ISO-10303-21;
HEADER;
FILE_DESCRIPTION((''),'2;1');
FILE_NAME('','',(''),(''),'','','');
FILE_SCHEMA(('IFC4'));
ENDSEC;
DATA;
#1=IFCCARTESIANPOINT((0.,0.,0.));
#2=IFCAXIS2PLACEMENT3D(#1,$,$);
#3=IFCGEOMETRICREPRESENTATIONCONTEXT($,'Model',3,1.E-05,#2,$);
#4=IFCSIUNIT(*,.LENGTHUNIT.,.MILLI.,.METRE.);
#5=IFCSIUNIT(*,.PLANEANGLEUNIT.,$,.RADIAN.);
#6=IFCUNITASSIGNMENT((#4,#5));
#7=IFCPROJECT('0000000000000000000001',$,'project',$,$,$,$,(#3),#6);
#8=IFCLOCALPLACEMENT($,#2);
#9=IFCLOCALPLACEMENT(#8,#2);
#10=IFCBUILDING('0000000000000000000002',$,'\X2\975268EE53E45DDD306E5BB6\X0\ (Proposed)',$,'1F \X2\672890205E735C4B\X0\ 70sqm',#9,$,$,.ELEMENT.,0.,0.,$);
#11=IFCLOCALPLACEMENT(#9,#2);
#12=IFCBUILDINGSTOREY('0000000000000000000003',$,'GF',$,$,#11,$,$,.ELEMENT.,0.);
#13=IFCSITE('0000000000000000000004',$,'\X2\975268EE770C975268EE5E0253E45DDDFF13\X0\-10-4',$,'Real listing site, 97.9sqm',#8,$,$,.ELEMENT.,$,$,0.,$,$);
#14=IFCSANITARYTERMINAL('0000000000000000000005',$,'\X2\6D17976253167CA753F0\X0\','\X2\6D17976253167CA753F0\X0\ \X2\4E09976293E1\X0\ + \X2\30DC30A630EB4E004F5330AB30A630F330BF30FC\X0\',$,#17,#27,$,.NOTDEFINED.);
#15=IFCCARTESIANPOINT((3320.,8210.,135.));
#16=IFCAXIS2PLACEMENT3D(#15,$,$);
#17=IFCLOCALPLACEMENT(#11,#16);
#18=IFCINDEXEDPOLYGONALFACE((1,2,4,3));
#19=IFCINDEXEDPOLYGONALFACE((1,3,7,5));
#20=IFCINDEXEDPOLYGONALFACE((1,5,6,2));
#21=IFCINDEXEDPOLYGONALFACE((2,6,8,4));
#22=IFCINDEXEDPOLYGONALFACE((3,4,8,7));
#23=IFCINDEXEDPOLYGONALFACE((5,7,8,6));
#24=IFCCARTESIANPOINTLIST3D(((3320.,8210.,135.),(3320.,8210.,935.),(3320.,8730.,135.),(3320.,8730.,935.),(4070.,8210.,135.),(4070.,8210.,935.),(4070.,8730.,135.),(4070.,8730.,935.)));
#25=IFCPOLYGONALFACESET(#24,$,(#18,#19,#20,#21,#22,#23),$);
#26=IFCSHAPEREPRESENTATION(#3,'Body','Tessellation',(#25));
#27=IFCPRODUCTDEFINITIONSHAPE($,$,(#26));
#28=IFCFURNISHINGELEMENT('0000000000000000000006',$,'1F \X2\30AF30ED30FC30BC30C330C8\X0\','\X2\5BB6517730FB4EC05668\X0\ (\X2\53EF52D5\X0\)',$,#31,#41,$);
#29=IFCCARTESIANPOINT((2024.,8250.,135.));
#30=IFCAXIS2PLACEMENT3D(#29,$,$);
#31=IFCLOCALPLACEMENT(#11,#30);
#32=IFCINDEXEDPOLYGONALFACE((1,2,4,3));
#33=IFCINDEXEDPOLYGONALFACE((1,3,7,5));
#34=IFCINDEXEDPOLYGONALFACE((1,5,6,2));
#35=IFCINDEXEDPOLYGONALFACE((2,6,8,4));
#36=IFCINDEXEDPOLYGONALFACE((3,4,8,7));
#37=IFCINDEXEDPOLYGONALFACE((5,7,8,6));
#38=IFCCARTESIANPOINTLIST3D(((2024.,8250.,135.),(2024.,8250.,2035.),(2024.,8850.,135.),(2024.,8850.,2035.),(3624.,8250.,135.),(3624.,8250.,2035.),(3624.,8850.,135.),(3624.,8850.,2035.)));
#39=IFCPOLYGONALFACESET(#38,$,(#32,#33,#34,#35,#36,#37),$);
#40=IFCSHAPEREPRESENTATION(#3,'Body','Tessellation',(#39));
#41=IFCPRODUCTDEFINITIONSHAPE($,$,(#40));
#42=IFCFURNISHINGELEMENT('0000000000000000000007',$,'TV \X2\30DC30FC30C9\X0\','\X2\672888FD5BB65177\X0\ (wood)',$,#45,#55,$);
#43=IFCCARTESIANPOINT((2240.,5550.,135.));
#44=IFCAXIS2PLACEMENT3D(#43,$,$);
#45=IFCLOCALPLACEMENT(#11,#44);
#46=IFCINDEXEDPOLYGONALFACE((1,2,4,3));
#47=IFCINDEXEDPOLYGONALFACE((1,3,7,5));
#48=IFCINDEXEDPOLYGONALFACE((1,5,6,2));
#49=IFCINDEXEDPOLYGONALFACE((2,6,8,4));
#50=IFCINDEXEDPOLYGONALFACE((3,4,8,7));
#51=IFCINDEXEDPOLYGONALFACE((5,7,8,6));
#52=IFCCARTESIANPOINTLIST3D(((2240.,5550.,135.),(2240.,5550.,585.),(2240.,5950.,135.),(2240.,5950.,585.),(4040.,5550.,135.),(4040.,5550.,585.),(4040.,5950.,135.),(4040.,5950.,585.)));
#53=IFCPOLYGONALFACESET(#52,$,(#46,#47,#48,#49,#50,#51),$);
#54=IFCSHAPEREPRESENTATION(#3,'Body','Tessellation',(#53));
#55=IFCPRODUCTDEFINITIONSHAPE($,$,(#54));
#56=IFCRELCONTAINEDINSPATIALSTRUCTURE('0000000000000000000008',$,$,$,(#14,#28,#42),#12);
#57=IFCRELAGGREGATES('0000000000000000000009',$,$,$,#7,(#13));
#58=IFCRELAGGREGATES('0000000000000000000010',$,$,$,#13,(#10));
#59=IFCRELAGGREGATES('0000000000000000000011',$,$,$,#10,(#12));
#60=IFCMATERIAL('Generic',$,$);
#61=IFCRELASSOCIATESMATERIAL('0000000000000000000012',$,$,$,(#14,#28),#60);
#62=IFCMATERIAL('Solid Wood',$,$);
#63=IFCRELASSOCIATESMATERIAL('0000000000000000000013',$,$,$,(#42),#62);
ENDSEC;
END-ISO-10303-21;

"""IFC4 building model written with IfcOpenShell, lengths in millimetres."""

from ifc_helpers import new_model, si_unit, frame, frame_2d, origin, place, context, project, spatial, rectangle, extrude, material, element, save


model = new_model("IFC4")

# Units and contexts
model_context = context("Model", 3, precision=1e-05, world=origin())
ifc_project = project(units=[si_unit("LENGTHUNIT", "METRE", prefix="MILLI"), si_unit("PLANEANGLEUNIT", "RADIAN")], contexts=[model_context])

# Site, building, storey
site_placement = place(None, origin())
site = spatial("IfcSite", under=ifc_project, at=site_placement, Name="青森県青森市古川３-10-4", ObjectType="Real listing site, 97.9sqm", CompositionType="ELEMENT", RefElevation=0.0)
building_placement = place(site_placement, origin())
building = spatial("IfcBuilding", under=site, at=building_placement, Name="青森古川の家 (Proposed)", ObjectType="1F 木造平屋 70sqm", CompositionType="ELEMENT", ElevationOfRefHeight=0.0, ElevationOfTerrain=0.0)
storey_placement = place(building_placement, origin())
storey = spatial("IfcBuildingStorey", under=building, at=storey_placement, Name="GF", CompositionType="ELEMENT", Elevation=0.0)

# Shared definitions
ifc_material_1 = material(Name="Solid Wood")

# Shared definitions
ifc_material_2 = material(Name="Generic")

# Sanitary terminal
sanitary_terminal_1_placement = place(storey_placement, frame((3320.0, 8210.0, 135.0)))
element("IfcSanitaryTerminal", 1, at=sanitary_terminal_1_placement, inside=storey, material=ifc_material_2, Name="洗面化粧台", Description="洗面化粧台 三面鏡 + ボウル一体カウンター", PredefinedType="NOTDEFINED", context=model_context, shape_type="SweptSolid", body=[
    extrude(rectangle(XDim=750.0, YDim=520.0, at=frame_2d((375.0, 260.0))), frame((3320.0, 8210.0, 135.0)), (0.0, 0.0, 1.0), 800.0),
])

# Furnishing elements
furnishing_1_placement = place(storey_placement, frame((2024.0, 8250.0, 135.0)))
element("IfcFurnishingElement", 2, at=furnishing_1_placement, inside=storey, material=ifc_material_2, Name="1F クローゼット", Description="家具・什器 (可動)", context=model_context, shape_type="SweptSolid", body=[
    extrude(rectangle(XDim=1600.0, YDim=600.0, at=frame_2d((800.0, 300.0))), frame((2024.0, 8250.0, 135.0)), (0.0, 0.0, 1.0), 1900.0),
])
furnishing_2_placement = place(storey_placement, frame((2240.0, 5550.0, 135.0)))
element("IfcFurnishingElement", 3, at=furnishing_2_placement, inside=storey, material=ifc_material_1, Name="TV ボード", Description="木製家具 (wood)", context=model_context, shape_type="SweptSolid", body=[
    extrude(rectangle(XDim=1800.0, YDim=400.0, at=frame_2d((900.0, 200.0))), frame((2240.0, 5550.0, 135.0)), (0.0, 0.0, 1.0), 450.0),
])

save(model, "model.ifc")
